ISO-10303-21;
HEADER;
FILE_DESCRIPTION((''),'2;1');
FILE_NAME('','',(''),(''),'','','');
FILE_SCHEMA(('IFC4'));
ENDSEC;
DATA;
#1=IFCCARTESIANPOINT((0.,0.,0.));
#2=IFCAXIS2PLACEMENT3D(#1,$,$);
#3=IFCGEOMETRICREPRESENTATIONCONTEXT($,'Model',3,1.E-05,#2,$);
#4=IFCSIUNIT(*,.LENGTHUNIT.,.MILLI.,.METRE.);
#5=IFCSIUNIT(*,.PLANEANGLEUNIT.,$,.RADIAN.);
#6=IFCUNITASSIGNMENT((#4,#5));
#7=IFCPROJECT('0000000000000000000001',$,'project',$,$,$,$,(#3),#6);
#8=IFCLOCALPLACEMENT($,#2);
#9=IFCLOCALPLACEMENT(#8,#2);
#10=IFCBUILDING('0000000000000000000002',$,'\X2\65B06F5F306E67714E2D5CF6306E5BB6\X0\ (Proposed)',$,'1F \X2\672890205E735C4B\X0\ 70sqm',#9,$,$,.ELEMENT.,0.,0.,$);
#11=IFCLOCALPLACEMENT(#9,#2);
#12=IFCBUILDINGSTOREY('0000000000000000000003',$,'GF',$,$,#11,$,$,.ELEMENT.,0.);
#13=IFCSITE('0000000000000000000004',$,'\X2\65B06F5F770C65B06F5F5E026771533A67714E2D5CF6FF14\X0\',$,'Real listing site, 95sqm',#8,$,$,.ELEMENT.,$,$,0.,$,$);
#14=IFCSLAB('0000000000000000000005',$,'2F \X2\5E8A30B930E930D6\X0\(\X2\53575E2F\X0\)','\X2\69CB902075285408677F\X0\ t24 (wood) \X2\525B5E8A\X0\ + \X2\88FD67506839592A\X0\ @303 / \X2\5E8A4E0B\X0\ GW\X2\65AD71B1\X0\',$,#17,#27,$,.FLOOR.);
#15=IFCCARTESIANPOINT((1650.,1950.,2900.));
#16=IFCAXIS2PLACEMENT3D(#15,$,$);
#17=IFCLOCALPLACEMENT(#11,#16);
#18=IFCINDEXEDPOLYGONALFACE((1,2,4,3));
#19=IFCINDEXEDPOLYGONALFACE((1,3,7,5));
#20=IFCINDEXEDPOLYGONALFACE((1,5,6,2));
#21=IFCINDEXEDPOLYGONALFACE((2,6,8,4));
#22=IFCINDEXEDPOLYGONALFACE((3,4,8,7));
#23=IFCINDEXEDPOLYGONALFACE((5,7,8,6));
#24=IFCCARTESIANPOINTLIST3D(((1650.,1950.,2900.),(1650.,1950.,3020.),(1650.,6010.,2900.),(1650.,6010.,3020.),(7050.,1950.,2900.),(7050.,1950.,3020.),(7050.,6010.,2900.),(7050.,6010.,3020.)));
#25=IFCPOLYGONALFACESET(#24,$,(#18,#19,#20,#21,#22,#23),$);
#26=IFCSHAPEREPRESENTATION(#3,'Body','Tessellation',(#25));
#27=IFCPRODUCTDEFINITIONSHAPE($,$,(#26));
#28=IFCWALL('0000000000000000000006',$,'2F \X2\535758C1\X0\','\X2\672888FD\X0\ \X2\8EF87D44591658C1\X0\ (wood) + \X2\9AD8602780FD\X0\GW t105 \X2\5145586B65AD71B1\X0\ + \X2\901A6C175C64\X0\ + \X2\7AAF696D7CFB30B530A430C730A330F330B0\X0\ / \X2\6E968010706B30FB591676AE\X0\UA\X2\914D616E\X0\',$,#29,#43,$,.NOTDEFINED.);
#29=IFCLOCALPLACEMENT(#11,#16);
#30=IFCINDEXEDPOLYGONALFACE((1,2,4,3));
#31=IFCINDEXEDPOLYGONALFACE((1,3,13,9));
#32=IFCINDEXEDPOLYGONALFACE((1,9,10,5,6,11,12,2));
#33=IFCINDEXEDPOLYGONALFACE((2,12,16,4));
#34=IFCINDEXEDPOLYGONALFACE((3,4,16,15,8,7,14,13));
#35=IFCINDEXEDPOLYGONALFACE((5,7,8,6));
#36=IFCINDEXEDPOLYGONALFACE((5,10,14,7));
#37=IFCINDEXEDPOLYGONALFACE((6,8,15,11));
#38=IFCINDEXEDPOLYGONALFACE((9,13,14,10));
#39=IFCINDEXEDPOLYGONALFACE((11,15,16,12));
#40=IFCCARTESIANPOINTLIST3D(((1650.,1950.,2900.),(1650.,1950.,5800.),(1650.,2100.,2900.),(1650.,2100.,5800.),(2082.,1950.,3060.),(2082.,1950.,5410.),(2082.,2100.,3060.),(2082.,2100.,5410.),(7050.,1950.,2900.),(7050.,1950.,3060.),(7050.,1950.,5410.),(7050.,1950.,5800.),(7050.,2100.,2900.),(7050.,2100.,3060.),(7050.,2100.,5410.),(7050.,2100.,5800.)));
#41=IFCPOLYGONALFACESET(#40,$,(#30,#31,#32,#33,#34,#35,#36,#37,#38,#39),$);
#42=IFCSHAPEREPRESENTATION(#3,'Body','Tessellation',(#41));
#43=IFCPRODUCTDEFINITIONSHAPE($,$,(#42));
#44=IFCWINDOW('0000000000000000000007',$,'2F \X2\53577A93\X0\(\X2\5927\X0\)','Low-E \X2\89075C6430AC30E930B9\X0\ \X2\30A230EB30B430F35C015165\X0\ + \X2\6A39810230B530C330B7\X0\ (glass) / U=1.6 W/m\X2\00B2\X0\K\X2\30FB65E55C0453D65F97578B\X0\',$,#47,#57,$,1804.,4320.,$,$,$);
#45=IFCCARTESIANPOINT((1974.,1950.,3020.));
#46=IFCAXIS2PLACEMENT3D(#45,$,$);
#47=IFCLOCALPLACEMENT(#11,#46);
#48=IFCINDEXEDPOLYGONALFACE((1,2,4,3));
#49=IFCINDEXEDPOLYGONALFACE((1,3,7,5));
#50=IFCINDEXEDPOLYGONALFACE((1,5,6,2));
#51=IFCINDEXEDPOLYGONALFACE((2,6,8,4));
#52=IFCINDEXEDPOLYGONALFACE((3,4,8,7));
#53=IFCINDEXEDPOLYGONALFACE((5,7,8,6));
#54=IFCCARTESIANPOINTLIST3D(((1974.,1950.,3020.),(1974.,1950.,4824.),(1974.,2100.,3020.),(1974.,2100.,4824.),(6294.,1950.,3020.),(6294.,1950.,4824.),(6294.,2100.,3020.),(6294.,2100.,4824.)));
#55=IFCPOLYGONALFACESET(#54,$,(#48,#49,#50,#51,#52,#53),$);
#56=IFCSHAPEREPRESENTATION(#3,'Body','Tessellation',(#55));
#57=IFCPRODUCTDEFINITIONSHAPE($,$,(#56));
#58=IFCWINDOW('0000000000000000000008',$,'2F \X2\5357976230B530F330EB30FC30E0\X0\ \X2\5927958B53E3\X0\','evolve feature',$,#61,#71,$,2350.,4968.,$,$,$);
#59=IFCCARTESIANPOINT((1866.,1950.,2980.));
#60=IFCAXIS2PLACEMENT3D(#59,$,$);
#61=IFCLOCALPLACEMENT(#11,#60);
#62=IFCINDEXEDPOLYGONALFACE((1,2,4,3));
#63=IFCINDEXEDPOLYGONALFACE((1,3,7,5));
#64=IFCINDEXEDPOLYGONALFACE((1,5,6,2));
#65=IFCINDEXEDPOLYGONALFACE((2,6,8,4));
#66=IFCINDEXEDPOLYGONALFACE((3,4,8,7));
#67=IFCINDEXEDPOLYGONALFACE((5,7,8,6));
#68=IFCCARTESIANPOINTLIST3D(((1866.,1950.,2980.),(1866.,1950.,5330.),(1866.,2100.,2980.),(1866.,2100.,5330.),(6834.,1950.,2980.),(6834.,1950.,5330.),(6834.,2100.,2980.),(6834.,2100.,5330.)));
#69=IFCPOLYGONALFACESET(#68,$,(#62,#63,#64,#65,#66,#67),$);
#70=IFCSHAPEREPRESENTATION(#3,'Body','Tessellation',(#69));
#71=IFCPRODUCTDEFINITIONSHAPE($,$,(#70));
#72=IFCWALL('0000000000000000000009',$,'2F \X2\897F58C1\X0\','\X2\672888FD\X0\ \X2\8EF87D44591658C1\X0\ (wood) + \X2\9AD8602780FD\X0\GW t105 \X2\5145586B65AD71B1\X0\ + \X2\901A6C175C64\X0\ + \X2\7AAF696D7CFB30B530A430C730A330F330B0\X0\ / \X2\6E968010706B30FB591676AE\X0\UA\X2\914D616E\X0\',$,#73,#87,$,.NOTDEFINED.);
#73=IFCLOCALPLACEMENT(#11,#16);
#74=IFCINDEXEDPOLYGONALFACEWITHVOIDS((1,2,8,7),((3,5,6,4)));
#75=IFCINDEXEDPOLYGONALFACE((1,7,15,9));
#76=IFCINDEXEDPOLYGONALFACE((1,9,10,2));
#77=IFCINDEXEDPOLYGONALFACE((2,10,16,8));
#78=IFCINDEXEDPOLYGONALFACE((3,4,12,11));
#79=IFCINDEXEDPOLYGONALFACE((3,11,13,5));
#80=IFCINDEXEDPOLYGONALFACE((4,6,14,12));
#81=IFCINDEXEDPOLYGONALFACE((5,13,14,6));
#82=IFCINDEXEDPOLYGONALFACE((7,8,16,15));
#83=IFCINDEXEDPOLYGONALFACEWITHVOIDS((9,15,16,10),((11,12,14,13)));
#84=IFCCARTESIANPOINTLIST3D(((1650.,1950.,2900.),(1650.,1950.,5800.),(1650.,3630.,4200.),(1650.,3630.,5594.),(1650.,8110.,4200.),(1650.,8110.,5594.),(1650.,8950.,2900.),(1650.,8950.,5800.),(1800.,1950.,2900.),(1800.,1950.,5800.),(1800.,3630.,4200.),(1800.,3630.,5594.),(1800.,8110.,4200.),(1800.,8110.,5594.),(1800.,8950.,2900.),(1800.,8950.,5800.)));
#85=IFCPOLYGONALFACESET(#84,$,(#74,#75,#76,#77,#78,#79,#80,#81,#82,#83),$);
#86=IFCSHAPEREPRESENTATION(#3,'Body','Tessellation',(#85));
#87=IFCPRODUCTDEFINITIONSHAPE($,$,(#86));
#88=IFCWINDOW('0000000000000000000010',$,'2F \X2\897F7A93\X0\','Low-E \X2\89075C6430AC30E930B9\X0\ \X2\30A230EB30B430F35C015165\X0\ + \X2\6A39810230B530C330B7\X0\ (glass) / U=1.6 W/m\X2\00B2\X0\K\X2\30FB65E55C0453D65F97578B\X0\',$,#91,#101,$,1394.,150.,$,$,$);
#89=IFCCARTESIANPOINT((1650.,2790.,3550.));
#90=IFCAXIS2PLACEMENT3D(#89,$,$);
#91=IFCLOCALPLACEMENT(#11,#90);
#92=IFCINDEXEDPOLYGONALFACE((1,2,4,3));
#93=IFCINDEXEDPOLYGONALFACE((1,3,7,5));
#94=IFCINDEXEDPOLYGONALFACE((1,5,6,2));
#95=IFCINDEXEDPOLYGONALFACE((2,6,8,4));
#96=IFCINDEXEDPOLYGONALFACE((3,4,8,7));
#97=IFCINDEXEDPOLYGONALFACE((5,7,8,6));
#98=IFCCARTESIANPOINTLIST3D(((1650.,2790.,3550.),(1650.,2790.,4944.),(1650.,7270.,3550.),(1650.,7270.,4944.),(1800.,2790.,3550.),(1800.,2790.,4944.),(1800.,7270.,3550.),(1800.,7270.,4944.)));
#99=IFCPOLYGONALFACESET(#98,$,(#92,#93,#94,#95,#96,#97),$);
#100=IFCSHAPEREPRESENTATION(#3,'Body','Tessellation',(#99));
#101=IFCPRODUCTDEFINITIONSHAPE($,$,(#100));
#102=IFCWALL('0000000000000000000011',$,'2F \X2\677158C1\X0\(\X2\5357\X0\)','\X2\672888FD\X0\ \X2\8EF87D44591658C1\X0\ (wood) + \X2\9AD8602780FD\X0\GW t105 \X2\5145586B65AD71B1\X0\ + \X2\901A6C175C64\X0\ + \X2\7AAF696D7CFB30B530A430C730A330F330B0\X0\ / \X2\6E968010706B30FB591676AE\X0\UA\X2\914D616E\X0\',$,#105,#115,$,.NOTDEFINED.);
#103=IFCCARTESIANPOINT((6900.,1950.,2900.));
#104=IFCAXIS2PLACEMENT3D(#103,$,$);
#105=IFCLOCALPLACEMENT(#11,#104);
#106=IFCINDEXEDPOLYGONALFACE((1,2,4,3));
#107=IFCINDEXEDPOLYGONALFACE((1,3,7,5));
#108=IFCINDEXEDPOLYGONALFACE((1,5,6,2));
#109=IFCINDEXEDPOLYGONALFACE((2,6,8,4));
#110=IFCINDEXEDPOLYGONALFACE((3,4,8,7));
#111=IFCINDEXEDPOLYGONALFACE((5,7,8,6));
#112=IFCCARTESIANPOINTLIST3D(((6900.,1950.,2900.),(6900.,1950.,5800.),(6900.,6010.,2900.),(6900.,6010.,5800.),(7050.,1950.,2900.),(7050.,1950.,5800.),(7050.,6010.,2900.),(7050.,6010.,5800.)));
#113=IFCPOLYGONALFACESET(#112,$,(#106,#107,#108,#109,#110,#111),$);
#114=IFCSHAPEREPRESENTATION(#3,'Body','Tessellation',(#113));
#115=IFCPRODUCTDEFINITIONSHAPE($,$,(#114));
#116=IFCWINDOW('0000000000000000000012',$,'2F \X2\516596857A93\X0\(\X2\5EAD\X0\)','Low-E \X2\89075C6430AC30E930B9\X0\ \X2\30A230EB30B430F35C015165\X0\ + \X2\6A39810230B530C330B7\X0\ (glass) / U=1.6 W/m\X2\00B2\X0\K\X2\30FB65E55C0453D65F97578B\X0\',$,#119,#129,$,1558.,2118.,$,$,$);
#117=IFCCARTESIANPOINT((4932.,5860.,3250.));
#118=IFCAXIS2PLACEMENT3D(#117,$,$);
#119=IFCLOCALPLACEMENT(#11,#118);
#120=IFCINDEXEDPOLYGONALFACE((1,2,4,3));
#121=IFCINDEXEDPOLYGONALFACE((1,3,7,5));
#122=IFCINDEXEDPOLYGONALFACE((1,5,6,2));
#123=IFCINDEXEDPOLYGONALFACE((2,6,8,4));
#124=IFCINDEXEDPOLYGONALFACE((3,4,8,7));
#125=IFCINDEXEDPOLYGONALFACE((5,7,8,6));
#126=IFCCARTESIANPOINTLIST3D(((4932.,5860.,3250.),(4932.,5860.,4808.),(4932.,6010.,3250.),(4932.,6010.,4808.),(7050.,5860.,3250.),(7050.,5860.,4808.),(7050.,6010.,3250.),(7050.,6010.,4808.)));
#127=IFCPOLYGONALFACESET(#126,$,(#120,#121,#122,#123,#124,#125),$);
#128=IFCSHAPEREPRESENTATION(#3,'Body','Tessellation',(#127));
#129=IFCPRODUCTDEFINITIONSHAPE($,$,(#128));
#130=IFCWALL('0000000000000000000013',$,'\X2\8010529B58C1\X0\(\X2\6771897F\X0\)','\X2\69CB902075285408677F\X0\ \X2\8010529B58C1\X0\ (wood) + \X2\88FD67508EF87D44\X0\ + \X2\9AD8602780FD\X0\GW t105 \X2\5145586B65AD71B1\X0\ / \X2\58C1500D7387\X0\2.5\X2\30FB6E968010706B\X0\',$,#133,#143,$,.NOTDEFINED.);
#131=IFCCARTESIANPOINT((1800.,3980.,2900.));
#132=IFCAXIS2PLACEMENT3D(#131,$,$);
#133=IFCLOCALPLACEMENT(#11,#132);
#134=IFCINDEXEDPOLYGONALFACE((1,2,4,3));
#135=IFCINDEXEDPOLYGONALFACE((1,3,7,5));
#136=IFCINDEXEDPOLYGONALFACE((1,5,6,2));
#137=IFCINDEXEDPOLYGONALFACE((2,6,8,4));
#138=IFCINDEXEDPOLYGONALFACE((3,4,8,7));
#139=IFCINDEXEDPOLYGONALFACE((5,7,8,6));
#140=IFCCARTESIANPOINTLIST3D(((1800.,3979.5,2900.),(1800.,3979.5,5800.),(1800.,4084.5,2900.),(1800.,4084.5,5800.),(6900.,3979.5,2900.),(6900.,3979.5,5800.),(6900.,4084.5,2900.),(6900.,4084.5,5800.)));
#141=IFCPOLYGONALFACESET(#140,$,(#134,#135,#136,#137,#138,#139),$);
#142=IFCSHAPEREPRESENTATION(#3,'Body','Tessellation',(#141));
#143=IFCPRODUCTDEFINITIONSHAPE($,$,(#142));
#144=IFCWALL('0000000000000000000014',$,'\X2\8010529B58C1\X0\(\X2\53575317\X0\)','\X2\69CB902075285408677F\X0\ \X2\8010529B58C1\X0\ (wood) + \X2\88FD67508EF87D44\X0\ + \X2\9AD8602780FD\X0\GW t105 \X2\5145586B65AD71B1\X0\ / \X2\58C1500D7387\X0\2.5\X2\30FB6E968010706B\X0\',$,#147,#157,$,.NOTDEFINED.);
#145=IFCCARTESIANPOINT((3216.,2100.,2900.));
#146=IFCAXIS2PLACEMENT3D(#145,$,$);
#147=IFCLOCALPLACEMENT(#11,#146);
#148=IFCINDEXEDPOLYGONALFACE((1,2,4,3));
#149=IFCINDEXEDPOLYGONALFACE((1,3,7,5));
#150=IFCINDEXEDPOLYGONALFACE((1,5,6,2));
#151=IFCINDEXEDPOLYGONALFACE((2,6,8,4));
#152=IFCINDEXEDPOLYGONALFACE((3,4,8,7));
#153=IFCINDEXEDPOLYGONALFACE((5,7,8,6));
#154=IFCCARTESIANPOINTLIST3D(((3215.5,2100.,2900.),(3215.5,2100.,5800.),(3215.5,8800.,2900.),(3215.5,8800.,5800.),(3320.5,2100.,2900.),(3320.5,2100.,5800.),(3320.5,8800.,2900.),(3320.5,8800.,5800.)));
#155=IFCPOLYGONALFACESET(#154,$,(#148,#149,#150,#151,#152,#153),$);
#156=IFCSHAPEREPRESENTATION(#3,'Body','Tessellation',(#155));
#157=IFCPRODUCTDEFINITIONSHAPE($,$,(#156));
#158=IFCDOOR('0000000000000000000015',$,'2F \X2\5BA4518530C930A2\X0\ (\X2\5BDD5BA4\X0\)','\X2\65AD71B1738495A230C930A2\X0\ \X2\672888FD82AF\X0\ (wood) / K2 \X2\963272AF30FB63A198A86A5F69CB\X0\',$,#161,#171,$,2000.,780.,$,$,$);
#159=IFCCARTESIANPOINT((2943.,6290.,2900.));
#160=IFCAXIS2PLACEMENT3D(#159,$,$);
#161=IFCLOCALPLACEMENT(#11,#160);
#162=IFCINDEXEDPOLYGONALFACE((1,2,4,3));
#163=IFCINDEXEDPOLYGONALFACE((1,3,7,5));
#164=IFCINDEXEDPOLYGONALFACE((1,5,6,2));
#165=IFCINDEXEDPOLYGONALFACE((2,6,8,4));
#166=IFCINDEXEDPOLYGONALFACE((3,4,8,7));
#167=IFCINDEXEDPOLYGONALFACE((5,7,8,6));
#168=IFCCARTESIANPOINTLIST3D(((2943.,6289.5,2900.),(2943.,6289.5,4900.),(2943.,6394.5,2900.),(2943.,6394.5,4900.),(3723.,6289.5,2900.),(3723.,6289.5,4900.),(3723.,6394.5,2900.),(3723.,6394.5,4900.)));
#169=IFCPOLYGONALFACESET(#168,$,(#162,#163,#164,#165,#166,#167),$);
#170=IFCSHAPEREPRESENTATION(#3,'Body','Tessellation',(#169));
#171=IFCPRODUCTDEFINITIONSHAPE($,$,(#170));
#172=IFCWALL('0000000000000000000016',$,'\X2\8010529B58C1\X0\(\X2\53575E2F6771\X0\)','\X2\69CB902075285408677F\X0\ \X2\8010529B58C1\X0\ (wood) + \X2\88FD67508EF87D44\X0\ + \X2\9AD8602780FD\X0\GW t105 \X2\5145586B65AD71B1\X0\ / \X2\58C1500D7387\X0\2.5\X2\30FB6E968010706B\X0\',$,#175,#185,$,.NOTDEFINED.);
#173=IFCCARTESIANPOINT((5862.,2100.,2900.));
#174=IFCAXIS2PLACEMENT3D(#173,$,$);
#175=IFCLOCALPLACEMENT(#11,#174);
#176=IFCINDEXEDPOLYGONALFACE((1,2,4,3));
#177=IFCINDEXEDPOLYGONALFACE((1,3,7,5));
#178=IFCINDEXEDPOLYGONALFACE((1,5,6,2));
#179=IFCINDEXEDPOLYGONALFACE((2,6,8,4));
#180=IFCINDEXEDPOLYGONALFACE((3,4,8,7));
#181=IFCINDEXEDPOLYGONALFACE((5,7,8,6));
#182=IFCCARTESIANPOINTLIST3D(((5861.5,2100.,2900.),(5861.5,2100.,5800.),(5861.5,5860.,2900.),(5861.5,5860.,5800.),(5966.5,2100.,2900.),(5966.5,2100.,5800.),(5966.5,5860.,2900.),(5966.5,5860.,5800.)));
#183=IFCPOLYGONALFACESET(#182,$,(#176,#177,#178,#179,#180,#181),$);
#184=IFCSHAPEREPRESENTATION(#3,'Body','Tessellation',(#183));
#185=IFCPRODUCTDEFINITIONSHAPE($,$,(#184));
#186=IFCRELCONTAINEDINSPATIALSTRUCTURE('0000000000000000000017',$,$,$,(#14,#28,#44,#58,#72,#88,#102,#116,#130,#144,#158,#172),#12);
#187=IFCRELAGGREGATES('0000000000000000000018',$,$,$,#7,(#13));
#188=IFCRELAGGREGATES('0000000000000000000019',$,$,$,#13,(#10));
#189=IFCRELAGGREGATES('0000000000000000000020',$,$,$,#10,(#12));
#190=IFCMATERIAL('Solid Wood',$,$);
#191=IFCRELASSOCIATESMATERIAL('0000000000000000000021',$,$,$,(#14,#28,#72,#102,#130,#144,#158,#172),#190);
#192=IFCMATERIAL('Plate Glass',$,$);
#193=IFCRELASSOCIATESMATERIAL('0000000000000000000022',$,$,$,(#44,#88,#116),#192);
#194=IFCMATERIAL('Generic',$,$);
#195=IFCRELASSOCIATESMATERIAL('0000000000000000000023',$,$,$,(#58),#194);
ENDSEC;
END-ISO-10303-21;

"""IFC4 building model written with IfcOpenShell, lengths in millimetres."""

from ifc_helpers import new_model, si_unit, frame, frame_2d, origin, place, context, project, spatial, rectangle, extrude, material, element, fill, save


model = new_model("IFC4")

# Units and contexts
model_context = context("Model", 3, precision=1e-05, world=origin())
ifc_project = project(units=[si_unit("LENGTHUNIT", "METRE", prefix="MILLI"), si_unit("PLANEANGLEUNIT", "RADIAN")], contexts=[model_context])

# Site, building, storey
site_placement = place(None, origin())
site = spatial("IfcSite", under=ifc_project, at=site_placement, Name="新潟県新潟市東区東中島４", ObjectType="Real listing site, 95sqm", CompositionType="ELEMENT", RefElevation=0.0)
building_placement = place(site_placement, origin())
building = spatial("IfcBuilding", under=site, at=building_placement, Name="新潟の東中島の家 (Proposed)", ObjectType="1F 木造平屋 70sqm", CompositionType="ELEMENT", ElevationOfRefHeight=0.0, ElevationOfTerrain=0.0)
storey_placement = place(building_placement, origin())
storey = spatial("IfcBuildingStorey", under=building, at=storey_placement, Name="GF", CompositionType="ELEMENT", Elevation=0.0)

# Slab
ifc_material_1 = material(Name="Solid Wood")
slab_placement = place(storey_placement, frame((1650.0, 1950.0, 2900.0)))
element("IfcSlab", 1, at=slab_placement, inside=storey, material=ifc_material_1, Name="2F 床スラブ(南帯)", Description="構造用合板 t24 (wood) 剛床 + 製材根太 @303 / 床下 GW断熱", PredefinedType="FLOOR", context=model_context, shape_type="SweptSolid", body=[
    extrude(rectangle(XDim=5400.0, YDim=4060.0, at=frame_2d((2700.0, 2030.0))), frame((1650.0, 1950.0, 2900.0)), (0.0, 0.0, 1.0), 120.0),
])

# Wall, openings, windows
wall_1_placement = place(storey_placement, frame((1650.0, 1950.0, 2900.0)))
wall_1 = element("IfcWall", 2, at=wall_1_placement, inside=storey, material=ifc_material_1, Name="2F 南壁", Description="木製 軸組外壁 (wood) + 高性能GW t105 充填断熱 + 通気層 + 窯業系サイディング / 準耐火・外皮UA配慮", PredefinedType="NOTDEFINED", context=model_context, shape_type="SweptSolid", body=[
    extrude(rectangle(XDim=5400.0, YDim=150.0, at=frame_2d((2700.0, 75.0))), frame((1650.0, 1950.0, 2900.0)), (0.0, 0.0, 1.0), 2900.0),
])
opening_1_placement = place(storey_placement, frame((1974.0, 1950.0, 3020.0)))
opening_1 = element("IfcOpeningElement", 3, at=opening_1_placement, cuts=wall_1, PredefinedType="NOTDEFINED", context=model_context, shape_type="SweptSolid", body=[
    extrude(rectangle(XDim=4320.0, YDim=150.0, at=frame_2d((2160.0, 75.0))), frame((1974.0, 1950.0, 3020.0)), (0.0, 0.0, 1.0), 1804.0),
])
opening_2_placement = place(storey_placement, frame((1866.0, 1950.0, 2980.0)))
opening_2 = element("IfcOpeningElement", 4, at=opening_2_placement, cuts=wall_1, PredefinedType="NOTDEFINED", context=model_context, shape_type="SweptSolid", body=[
    extrude(rectangle(XDim=4968.0, YDim=150.0, at=frame_2d((2484.0, 75.0))), frame((1866.0, 1950.0, 2980.0)), (0.0, 0.0, 1.0), 2350.0),
])
ifc_material_2 = material(Name="Plate Glass")
window_1_placement = place(storey_placement, frame((1974.0, 1950.0, 3020.0)))
window_1 = element("IfcWindow", 5, at=window_1_placement, inside=storey, material=ifc_material_2, Name="2F 南窓(大)", Description="Low-E 複層ガラス アルゴン封入 + 樹脂サッシ (glass) / U=1.6 W/m²K・日射取得型", OverallHeight=1804.0, OverallWidth=4320.0, context=model_context, shape_type="SweptSolid", body=[
    extrude(rectangle(XDim=4320.0, YDim=150.0, at=frame_2d((2160.0, 75.0))), frame((1974.0, 1950.0, 3020.0)), (0.0, 0.0, 1.0), 1804.0),
])
fill(opening_1, window_1)
ifc_material_3 = material(Name="Generic")
window_2_placement = place(storey_placement, frame((1866.0, 1950.0, 2980.0)))
window_2 = element("IfcWindow", 6, at=window_2_placement, inside=storey, material=ifc_material_3, Name="2F 南面サンルーム 大開口", Description="evolve feature", OverallHeight=2350.0, OverallWidth=4968.0, context=model_context, shape_type="SweptSolid", body=[
    extrude(rectangle(XDim=4968.0, YDim=150.0, at=frame_2d((2484.0, 75.0))), frame((1866.0, 1950.0, 2980.0)), (0.0, 0.0, 1.0), 2350.0),
])
fill(opening_2, window_2)

# Walls, openings, windows
wall_2_placement = place(storey_placement, frame((1650.0, 1950.0, 2900.0)))
wall_2 = element("IfcWall", 7, at=wall_2_placement, inside=storey, material=ifc_material_1, Name="2F 西壁", Description="木製 軸組外壁 (wood) + 高性能GW t105 充填断熱 + 通気層 + 窯業系サイディング / 準耐火・外皮UA配慮", PredefinedType="NOTDEFINED", context=model_context, shape_type="SweptSolid", body=[
    extrude(rectangle(XDim=150.0, YDim=7000.0, at=frame_2d((75.0, 3500.0))), frame((1650.0, 1950.0, 2900.0)), (0.0, 0.0, 1.0), 2900.0),
])
opening_3_placement = place(storey_placement, frame((1650.0, 2790.0, 3550.0)))
opening_3 = element("IfcOpeningElement", 8, at=opening_3_placement, cuts=wall_2, PredefinedType="NOTDEFINED", context=model_context, shape_type="SweptSolid", body=[
    extrude(rectangle(XDim=150.0, YDim=4480.0, at=frame_2d((75.0, 2240.0))), frame((1650.0, 2790.0, 3550.0)), (0.0, 0.0, 1.0), 1394.0),
])
window_3_placement = place(storey_placement, frame((1650.0, 2790.0, 3550.0)))
window_3 = element("IfcWindow", 9, at=window_3_placement, inside=storey, material=ifc_material_2, Name="2F 西窓", Description="Low-E 複層ガラス アルゴン封入 + 樹脂サッシ (glass) / U=1.6 W/m²K・日射取得型", OverallHeight=1394.0, OverallWidth=150.0, context=model_context, shape_type="SweptSolid", body=[
    extrude(rectangle(XDim=150.0, YDim=4480.0, at=frame_2d((75.0, 2240.0))), frame((1650.0, 2790.0, 3550.0)), (0.0, 0.0, 1.0), 1394.0),
])
fill(opening_3, window_3)
wall_3_placement = place(storey_placement, frame((6900.0, 1950.0, 2900.0)))
wall_3 = element("IfcWall", 10, at=wall_3_placement, inside=storey, material=ifc_material_1, Name="2F 東壁(南)", Description="木製 軸組外壁 (wood) + 高性能GW t105 充填断熱 + 通気層 + 窯業系サイディング / 準耐火・外皮UA配慮", PredefinedType="NOTDEFINED", context=model_context, shape_type="SweptSolid", body=[
    extrude(rectangle(XDim=150.0, YDim=4060.0, at=frame_2d((75.0, 2030.0))), frame((6900.0, 1950.0, 2900.0)), (0.0, 0.0, 1.0), 2900.0),
])
opening_4_placement = place(storey_placement, frame((4932.0, 5860.0, 3250.0)))
opening_4 = element("IfcOpeningElement", 11, at=opening_4_placement, cuts=wall_3, PredefinedType="NOTDEFINED", context=model_context, shape_type="SweptSolid", body=[
    extrude(rectangle(XDim=2118.0, YDim=150.0, at=frame_2d((1059.0, 75.0))), frame((4932.0, 5860.0, 3250.0)), (0.0, 0.0, 1.0), 1558.0),
])
window_4_placement = place(storey_placement, frame((4932.0, 5860.0, 3250.0)))
window_4 = element("IfcWindow", 12, at=window_4_placement, inside=storey, material=ifc_material_2, Name="2F 入隅窓(庭)", Description="Low-E 複層ガラス アルゴン封入 + 樹脂サッシ (glass) / U=1.6 W/m²K・日射取得型", OverallHeight=1558.0, OverallWidth=2118.0, context=model_context, shape_type="SweptSolid", body=[
    extrude(rectangle(XDim=2118.0, YDim=150.0, at=frame_2d((1059.0, 75.0))), frame((4932.0, 5860.0, 3250.0)), (0.0, 0.0, 1.0), 1558.0),
])
fill(opening_4, window_4)

# Wall
wall_4_placement = place(storey_placement, frame((1800.0, 3980.0, 2900.0)))
element("IfcWall", 13, at=wall_4_placement, inside=storey, material=ifc_material_1, Name="耐力壁(東西)", Description="構造用合板 耐力壁 (wood) + 製材軸組 + 高性能GW t105 充填断熱 / 壁倍率2.5・準耐火", PredefinedType="NOTDEFINED", context=model_context, shape_type="SweptSolid", body=[
    extrude(rectangle(XDim=5100.0, YDim=105.0, at=frame_2d((2550.0, 52.0))), frame((1800.0, 3980.0, 2900.0)), (0.0, 0.0, 1.0), 2900.0),
])

# Wall, opening, door
wall_5_placement = place(storey_placement, frame((3216.0, 2100.0, 2900.0)))
wall_5 = element("IfcWall", 14, at=wall_5_placement, inside=storey, material=ifc_material_1, Name="耐力壁(南北)", Description="構造用合板 耐力壁 (wood) + 製材軸組 + 高性能GW t105 充填断熱 / 壁倍率2.5・準耐火", PredefinedType="NOTDEFINED", context=model_context, shape_type="SweptSolid", body=[
    extrude(rectangle(XDim=105.0, YDim=6700.0, at=frame_2d((52.0, 3350.0))), frame((3216.0, 2100.0, 2900.0)), (0.0, 0.0, 1.0), 2900.0),
])
opening_5_placement = place(storey_placement, frame((2943.0, 6290.0, 2900.0)))
opening_5 = element("IfcOpeningElement", 15, at=opening_5_placement, cuts=wall_5, PredefinedType="NOTDEFINED", context=model_context, shape_type="SweptSolid", body=[
    extrude(rectangle(XDim=780.0, YDim=105.0, at=frame_2d((390.0, 52.0))), frame((2943.0, 6290.0, 2900.0)), (0.0, 0.0, 1.0), 2000.0),
])
door_placement = place(storey_placement, frame((2943.0, 6290.0, 2900.0)))
door = element("IfcDoor", 16, at=door_placement, inside=storey, material=ifc_material_1, Name="2F 室内ドア (寝室)", Description="断熱玄関ドア 木製芯 (wood) / K2 防犯・採風機構", OverallHeight=2000.0, OverallWidth=780.0, context=model_context, shape_type="SweptSolid", body=[
    extrude(rectangle(XDim=780.0, YDim=105.0, at=frame_2d((390.0, 52.0))), frame((2943.0, 6290.0, 2900.0)), (0.0, 0.0, 1.0), 2000.0),
])
fill(opening_5, door)

# Wall
wall_6_placement = place(storey_placement, frame((5862.0, 2100.0, 2900.0)))
element("IfcWall", 17, at=wall_6_placement, inside=storey, material=ifc_material_1, Name="耐力壁(南帯東)", Description="構造用合板 耐力壁 (wood) + 製材軸組 + 高性能GW t105 充填断熱 / 壁倍率2.5・準耐火", PredefinedType="NOTDEFINED", context=model_context, shape_type="SweptSolid", body=[
    extrude(rectangle(XDim=105.0, YDim=3760.0, at=frame_2d((52.0, 1880.0))), frame((5862.0, 2100.0, 2900.0)), (0.0, 0.0, 1.0), 2900.0),
])

save(model, "model.ifc")
